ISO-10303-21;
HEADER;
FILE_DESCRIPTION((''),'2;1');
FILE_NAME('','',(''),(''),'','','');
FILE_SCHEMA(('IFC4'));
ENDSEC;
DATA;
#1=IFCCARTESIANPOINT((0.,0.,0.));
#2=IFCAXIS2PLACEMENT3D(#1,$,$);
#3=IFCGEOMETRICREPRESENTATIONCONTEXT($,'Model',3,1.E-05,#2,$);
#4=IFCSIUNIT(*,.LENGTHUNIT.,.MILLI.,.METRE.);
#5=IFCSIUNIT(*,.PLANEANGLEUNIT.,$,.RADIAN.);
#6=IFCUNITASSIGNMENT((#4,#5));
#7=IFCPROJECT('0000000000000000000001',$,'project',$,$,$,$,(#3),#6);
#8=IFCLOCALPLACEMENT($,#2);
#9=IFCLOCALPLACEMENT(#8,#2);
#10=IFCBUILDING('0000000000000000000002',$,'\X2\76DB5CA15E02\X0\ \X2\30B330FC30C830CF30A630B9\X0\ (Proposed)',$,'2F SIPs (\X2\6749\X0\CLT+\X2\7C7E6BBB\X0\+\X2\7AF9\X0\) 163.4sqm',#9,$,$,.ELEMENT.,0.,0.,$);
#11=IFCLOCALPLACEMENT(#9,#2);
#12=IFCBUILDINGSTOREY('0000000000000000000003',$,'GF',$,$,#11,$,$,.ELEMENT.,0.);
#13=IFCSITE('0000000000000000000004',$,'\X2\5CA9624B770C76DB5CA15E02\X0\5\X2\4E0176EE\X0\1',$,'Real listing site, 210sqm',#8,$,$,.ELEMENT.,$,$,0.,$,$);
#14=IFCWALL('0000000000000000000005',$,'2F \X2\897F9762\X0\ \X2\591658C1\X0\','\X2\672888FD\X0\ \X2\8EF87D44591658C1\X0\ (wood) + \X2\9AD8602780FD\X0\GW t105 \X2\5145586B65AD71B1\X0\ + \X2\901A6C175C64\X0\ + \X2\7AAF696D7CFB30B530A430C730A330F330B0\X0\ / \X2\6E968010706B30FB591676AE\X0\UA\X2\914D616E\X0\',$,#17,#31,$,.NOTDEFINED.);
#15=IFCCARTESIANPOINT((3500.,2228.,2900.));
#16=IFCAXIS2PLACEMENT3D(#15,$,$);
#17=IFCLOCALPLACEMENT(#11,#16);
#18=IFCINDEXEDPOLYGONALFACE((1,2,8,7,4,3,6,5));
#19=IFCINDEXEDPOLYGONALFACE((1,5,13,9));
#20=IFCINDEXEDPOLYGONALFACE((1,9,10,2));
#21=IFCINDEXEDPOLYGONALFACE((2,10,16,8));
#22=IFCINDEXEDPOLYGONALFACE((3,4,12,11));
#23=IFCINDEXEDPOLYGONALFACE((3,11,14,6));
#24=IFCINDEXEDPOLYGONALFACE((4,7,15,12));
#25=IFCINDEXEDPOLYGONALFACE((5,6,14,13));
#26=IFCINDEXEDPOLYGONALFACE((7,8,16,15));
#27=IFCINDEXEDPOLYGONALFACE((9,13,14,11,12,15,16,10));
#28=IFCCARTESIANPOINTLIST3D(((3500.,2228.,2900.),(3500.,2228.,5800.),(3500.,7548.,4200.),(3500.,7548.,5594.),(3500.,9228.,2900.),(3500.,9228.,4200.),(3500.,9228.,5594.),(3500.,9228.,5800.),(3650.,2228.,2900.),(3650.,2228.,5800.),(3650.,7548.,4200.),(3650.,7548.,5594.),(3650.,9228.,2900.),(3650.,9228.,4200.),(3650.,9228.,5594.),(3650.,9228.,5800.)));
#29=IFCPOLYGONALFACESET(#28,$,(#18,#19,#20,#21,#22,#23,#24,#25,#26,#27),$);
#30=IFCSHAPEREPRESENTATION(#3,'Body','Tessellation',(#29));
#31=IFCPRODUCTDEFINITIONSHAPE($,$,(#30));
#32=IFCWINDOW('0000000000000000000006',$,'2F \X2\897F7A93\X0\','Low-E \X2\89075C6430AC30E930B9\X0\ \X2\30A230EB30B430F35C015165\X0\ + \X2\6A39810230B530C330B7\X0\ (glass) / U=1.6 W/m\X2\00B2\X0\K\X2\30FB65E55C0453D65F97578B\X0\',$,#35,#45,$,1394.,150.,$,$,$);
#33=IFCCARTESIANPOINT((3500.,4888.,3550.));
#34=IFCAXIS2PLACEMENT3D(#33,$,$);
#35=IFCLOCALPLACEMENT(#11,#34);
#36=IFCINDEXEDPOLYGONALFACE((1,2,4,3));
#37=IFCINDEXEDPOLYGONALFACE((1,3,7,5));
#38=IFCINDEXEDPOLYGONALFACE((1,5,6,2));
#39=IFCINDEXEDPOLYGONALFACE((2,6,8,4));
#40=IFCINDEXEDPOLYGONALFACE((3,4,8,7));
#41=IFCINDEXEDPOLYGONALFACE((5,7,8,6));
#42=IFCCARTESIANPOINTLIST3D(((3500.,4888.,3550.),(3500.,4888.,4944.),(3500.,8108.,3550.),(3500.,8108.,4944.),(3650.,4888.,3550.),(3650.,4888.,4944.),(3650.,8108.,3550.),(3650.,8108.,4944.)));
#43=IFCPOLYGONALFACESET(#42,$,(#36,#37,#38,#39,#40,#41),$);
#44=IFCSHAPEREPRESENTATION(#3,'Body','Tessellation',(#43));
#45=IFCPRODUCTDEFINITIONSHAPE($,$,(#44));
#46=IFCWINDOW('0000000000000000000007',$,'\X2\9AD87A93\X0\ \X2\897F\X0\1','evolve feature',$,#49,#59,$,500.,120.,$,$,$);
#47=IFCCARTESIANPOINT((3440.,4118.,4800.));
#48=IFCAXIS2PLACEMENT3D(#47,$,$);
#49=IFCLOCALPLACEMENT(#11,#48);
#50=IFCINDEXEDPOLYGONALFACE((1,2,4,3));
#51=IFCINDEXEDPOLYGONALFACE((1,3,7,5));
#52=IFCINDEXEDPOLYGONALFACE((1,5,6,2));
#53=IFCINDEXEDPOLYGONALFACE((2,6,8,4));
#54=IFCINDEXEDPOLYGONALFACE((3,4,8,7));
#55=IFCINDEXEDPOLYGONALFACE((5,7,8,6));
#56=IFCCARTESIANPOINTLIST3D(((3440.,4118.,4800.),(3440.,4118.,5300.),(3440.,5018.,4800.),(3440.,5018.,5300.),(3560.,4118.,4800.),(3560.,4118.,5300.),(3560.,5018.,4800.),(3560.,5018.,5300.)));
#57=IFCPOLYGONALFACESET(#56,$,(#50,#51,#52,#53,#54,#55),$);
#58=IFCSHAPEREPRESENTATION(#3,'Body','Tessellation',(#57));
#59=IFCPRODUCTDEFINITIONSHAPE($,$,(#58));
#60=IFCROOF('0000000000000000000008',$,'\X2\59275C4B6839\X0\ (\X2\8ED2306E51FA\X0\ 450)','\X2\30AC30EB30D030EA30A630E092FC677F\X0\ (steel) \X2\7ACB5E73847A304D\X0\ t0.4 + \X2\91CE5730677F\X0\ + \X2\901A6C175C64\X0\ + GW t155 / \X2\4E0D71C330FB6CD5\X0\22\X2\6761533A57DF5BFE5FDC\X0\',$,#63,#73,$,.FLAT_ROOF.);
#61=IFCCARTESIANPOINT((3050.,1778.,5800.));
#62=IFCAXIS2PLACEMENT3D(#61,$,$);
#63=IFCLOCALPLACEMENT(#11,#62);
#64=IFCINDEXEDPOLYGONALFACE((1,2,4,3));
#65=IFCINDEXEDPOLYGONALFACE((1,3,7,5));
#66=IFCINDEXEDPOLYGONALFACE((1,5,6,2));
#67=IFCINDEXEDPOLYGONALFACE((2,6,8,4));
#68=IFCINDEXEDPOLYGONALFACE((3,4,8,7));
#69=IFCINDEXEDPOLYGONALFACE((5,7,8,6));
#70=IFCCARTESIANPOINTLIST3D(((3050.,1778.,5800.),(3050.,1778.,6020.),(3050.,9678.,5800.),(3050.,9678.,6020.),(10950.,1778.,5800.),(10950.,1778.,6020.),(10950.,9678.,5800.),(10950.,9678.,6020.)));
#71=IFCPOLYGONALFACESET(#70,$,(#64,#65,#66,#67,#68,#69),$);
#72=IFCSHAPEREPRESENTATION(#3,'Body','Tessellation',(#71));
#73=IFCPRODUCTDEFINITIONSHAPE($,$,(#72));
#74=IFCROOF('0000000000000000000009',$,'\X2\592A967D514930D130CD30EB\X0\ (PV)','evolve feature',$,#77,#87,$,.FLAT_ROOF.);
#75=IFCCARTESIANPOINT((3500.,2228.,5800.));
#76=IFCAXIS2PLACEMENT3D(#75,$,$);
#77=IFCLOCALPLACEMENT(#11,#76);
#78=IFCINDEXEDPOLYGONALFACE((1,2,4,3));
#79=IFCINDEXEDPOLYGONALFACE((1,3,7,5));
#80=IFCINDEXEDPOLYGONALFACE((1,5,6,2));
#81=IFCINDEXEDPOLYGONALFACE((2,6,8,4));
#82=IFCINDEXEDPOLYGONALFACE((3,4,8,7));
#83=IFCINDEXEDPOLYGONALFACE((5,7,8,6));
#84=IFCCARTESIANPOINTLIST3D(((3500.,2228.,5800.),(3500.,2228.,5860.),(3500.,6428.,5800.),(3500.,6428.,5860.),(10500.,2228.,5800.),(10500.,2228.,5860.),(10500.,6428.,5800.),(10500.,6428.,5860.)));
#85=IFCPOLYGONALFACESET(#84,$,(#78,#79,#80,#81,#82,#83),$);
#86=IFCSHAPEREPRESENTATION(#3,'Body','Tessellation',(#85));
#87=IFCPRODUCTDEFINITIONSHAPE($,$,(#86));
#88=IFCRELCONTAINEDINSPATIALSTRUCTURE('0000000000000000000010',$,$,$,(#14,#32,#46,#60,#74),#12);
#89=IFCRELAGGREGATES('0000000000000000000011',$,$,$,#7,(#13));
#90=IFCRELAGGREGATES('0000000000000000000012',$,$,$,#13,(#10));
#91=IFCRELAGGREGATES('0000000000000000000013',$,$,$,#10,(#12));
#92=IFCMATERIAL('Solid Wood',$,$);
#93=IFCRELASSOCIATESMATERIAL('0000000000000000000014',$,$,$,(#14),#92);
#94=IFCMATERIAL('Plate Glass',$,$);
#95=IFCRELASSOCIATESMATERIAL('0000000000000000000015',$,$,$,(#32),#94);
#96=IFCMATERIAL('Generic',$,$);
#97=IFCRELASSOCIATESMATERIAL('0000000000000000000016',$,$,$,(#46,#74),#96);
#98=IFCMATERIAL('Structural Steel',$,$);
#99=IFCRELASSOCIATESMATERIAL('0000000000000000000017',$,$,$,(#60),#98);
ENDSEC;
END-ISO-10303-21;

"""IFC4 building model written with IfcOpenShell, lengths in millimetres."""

from ifc_helpers import new_model, si_unit, frame, frame_2d, origin, place, context, project, spatial, rectangle, extrude, material, element, fill, save


model = new_model("IFC4")

# Units and contexts
model_context = context("Model", 3, precision=1e-05, world=origin())
ifc_project = project(units=[si_unit("LENGTHUNIT", "METRE", prefix="MILLI"), si_unit("PLANEANGLEUNIT", "RADIAN")], contexts=[model_context])

# Site, building, storey
site_placement = place(None, origin())
site = spatial("IfcSite", under=ifc_project, at=site_placement, Name="岩手県盛岡市5丁目1", ObjectType="Real listing site, 210sqm", CompositionType="ELEMENT", RefElevation=0.0)
building_placement = place(site_placement, origin())
building = spatial("IfcBuilding", under=site, at=building_placement, Name="盛岡市 コートハウス (Proposed)", ObjectType="2F SIPs (杉CLT+籾殻+竹) 163.4sqm", CompositionType="ELEMENT", ElevationOfRefHeight=0.0, ElevationOfTerrain=0.0)
storey_placement = place(building_placement, origin())
storey = spatial("IfcBuildingStorey", under=building, at=storey_placement, Name="GF", CompositionType="ELEMENT", Elevation=0.0)

# Shared definitions
ifc_material_1 = material(Name="Solid Wood")
ifc_material_2 = material(Name="Generic")

# Shared definitions
ifc_material_3 = material(Name="Plate Glass")

# Wall, openings, windows
wall_1_placement = place(storey_placement, frame((3500.0, 2228.0, 2900.0)))
wall_1 = element("IfcWall", 1, at=wall_1_placement, inside=storey, material=ifc_material_1, Name="2F 西面 外壁", Description="木製 軸組外壁 (wood) + 高性能GW t105 充填断熱 + 通気層 + 窯業系サイディング / 準耐火・外皮UA配慮", PredefinedType="NOTDEFINED", context=model_context, shape_type="SweptSolid", body=[
    extrude(rectangle(XDim=150.0, YDim=7000.0, at=frame_2d((75.0, 3500.0))), frame((3500.0, 2228.0, 2900.0)), (0.0, 0.0, 1.0), 2900.0),
])
opening_1_placement = place(storey_placement, frame((3500.0, 4888.0, 3550.0)))
opening_1 = element("IfcOpeningElement", 2, at=opening_1_placement, cuts=wall_1, PredefinedType="NOTDEFINED", context=model_context, shape_type="SweptSolid", body=[
    extrude(rectangle(XDim=150.0, YDim=3220.0, at=frame_2d((75.0, 1610.0))), frame((3500.0, 4888.0, 3550.0)), (0.0, 0.0, 1.0), 1394.0),
])
opening_2_placement = place(storey_placement, frame((3440.0, 4118.0, 4800.0)))
opening_2 = element("IfcOpeningElement", 3, at=opening_2_placement, cuts=wall_1, PredefinedType="NOTDEFINED", context=model_context, shape_type="SweptSolid", body=[
    extrude(rectangle(XDim=120.0, YDim=900.0, at=frame_2d((60.0, 450.0))), frame((3440.0, 4118.0, 4800.0)), (0.0, 0.0, 1.0), 500.0),
])
window_1_placement = place(storey_placement, frame((3500.0, 4888.0, 3550.0)))
window_1 = element("IfcWindow", 4, at=window_1_placement, inside=storey, material=ifc_material_3, Name="2F 西窓", Description="Low-E 複層ガラス アルゴン封入 + 樹脂サッシ (glass) / U=1.6 W/m²K・日射取得型", OverallHeight=1394.0, OverallWidth=150.0, context=model_context, shape_type="SweptSolid", body=[
    extrude(rectangle(XDim=150.0, YDim=3220.0, at=frame_2d((75.0, 1610.0))), frame((3500.0, 4888.0, 3550.0)), (0.0, 0.0, 1.0), 1394.0),
])
fill(opening_1, window_1)
window_2_placement = place(storey_placement, frame((3440.0, 4118.0, 4800.0)))
window_2 = element("IfcWindow", 5, at=window_2_placement, inside=storey, material=ifc_material_2, Name="高窓 西1", Description="evolve feature", OverallHeight=500.0, OverallWidth=120.0, context=model_context, shape_type="SweptSolid", body=[
    extrude(rectangle(XDim=120.0, YDim=900.0, at=frame_2d((60.0, 450.0))), frame((3440.0, 4118.0, 4800.0)), (0.0, 0.0, 1.0), 500.0),
])
fill(opening_2, window_2)

# Roofs
ifc_material_4 = material(Name="Structural Steel")
roof_1_placement = place(storey_placement, frame((3050.0, 1778.0, 5800.0)))
element("IfcRoof", 6, at=roof_1_placement, inside=storey, material=ifc_material_4, Name="大屋根 (軒の出 450)", Description="ガルバリウム鋼板 (steel) 立平葺き t0.4 + 野地板 + 通気層 + GW t155 / 不燃・法22条区域対応", PredefinedType="FLAT_ROOF", context=model_context, shape_type="SweptSolid", body=[
    extrude(rectangle(XDim=7900.0, YDim=7900.0, at=frame_2d((3950.0, 3950.0))), frame((3050.0, 1778.0, 5800.0)), (0.0, 0.0, 1.0), 220.0),
])
roof_2_placement = place(storey_placement, frame((3500.0, 2228.0, 5800.0)))
element("IfcRoof", 7, at=roof_2_placement, inside=storey, material=ifc_material_2, Name="太陽光パネル (PV)", Description="evolve feature", PredefinedType="FLAT_ROOF", context=model_context, shape_type="SweptSolid", body=[
    extrude(rectangle(XDim=7000.0, YDim=4200.0, at=frame_2d((3500.0, 2100.0))), frame((3500.0, 2228.0, 5800.0)), (0.0, 0.0, 1.0), 60.0),
])

save(model, "model.ifc")
